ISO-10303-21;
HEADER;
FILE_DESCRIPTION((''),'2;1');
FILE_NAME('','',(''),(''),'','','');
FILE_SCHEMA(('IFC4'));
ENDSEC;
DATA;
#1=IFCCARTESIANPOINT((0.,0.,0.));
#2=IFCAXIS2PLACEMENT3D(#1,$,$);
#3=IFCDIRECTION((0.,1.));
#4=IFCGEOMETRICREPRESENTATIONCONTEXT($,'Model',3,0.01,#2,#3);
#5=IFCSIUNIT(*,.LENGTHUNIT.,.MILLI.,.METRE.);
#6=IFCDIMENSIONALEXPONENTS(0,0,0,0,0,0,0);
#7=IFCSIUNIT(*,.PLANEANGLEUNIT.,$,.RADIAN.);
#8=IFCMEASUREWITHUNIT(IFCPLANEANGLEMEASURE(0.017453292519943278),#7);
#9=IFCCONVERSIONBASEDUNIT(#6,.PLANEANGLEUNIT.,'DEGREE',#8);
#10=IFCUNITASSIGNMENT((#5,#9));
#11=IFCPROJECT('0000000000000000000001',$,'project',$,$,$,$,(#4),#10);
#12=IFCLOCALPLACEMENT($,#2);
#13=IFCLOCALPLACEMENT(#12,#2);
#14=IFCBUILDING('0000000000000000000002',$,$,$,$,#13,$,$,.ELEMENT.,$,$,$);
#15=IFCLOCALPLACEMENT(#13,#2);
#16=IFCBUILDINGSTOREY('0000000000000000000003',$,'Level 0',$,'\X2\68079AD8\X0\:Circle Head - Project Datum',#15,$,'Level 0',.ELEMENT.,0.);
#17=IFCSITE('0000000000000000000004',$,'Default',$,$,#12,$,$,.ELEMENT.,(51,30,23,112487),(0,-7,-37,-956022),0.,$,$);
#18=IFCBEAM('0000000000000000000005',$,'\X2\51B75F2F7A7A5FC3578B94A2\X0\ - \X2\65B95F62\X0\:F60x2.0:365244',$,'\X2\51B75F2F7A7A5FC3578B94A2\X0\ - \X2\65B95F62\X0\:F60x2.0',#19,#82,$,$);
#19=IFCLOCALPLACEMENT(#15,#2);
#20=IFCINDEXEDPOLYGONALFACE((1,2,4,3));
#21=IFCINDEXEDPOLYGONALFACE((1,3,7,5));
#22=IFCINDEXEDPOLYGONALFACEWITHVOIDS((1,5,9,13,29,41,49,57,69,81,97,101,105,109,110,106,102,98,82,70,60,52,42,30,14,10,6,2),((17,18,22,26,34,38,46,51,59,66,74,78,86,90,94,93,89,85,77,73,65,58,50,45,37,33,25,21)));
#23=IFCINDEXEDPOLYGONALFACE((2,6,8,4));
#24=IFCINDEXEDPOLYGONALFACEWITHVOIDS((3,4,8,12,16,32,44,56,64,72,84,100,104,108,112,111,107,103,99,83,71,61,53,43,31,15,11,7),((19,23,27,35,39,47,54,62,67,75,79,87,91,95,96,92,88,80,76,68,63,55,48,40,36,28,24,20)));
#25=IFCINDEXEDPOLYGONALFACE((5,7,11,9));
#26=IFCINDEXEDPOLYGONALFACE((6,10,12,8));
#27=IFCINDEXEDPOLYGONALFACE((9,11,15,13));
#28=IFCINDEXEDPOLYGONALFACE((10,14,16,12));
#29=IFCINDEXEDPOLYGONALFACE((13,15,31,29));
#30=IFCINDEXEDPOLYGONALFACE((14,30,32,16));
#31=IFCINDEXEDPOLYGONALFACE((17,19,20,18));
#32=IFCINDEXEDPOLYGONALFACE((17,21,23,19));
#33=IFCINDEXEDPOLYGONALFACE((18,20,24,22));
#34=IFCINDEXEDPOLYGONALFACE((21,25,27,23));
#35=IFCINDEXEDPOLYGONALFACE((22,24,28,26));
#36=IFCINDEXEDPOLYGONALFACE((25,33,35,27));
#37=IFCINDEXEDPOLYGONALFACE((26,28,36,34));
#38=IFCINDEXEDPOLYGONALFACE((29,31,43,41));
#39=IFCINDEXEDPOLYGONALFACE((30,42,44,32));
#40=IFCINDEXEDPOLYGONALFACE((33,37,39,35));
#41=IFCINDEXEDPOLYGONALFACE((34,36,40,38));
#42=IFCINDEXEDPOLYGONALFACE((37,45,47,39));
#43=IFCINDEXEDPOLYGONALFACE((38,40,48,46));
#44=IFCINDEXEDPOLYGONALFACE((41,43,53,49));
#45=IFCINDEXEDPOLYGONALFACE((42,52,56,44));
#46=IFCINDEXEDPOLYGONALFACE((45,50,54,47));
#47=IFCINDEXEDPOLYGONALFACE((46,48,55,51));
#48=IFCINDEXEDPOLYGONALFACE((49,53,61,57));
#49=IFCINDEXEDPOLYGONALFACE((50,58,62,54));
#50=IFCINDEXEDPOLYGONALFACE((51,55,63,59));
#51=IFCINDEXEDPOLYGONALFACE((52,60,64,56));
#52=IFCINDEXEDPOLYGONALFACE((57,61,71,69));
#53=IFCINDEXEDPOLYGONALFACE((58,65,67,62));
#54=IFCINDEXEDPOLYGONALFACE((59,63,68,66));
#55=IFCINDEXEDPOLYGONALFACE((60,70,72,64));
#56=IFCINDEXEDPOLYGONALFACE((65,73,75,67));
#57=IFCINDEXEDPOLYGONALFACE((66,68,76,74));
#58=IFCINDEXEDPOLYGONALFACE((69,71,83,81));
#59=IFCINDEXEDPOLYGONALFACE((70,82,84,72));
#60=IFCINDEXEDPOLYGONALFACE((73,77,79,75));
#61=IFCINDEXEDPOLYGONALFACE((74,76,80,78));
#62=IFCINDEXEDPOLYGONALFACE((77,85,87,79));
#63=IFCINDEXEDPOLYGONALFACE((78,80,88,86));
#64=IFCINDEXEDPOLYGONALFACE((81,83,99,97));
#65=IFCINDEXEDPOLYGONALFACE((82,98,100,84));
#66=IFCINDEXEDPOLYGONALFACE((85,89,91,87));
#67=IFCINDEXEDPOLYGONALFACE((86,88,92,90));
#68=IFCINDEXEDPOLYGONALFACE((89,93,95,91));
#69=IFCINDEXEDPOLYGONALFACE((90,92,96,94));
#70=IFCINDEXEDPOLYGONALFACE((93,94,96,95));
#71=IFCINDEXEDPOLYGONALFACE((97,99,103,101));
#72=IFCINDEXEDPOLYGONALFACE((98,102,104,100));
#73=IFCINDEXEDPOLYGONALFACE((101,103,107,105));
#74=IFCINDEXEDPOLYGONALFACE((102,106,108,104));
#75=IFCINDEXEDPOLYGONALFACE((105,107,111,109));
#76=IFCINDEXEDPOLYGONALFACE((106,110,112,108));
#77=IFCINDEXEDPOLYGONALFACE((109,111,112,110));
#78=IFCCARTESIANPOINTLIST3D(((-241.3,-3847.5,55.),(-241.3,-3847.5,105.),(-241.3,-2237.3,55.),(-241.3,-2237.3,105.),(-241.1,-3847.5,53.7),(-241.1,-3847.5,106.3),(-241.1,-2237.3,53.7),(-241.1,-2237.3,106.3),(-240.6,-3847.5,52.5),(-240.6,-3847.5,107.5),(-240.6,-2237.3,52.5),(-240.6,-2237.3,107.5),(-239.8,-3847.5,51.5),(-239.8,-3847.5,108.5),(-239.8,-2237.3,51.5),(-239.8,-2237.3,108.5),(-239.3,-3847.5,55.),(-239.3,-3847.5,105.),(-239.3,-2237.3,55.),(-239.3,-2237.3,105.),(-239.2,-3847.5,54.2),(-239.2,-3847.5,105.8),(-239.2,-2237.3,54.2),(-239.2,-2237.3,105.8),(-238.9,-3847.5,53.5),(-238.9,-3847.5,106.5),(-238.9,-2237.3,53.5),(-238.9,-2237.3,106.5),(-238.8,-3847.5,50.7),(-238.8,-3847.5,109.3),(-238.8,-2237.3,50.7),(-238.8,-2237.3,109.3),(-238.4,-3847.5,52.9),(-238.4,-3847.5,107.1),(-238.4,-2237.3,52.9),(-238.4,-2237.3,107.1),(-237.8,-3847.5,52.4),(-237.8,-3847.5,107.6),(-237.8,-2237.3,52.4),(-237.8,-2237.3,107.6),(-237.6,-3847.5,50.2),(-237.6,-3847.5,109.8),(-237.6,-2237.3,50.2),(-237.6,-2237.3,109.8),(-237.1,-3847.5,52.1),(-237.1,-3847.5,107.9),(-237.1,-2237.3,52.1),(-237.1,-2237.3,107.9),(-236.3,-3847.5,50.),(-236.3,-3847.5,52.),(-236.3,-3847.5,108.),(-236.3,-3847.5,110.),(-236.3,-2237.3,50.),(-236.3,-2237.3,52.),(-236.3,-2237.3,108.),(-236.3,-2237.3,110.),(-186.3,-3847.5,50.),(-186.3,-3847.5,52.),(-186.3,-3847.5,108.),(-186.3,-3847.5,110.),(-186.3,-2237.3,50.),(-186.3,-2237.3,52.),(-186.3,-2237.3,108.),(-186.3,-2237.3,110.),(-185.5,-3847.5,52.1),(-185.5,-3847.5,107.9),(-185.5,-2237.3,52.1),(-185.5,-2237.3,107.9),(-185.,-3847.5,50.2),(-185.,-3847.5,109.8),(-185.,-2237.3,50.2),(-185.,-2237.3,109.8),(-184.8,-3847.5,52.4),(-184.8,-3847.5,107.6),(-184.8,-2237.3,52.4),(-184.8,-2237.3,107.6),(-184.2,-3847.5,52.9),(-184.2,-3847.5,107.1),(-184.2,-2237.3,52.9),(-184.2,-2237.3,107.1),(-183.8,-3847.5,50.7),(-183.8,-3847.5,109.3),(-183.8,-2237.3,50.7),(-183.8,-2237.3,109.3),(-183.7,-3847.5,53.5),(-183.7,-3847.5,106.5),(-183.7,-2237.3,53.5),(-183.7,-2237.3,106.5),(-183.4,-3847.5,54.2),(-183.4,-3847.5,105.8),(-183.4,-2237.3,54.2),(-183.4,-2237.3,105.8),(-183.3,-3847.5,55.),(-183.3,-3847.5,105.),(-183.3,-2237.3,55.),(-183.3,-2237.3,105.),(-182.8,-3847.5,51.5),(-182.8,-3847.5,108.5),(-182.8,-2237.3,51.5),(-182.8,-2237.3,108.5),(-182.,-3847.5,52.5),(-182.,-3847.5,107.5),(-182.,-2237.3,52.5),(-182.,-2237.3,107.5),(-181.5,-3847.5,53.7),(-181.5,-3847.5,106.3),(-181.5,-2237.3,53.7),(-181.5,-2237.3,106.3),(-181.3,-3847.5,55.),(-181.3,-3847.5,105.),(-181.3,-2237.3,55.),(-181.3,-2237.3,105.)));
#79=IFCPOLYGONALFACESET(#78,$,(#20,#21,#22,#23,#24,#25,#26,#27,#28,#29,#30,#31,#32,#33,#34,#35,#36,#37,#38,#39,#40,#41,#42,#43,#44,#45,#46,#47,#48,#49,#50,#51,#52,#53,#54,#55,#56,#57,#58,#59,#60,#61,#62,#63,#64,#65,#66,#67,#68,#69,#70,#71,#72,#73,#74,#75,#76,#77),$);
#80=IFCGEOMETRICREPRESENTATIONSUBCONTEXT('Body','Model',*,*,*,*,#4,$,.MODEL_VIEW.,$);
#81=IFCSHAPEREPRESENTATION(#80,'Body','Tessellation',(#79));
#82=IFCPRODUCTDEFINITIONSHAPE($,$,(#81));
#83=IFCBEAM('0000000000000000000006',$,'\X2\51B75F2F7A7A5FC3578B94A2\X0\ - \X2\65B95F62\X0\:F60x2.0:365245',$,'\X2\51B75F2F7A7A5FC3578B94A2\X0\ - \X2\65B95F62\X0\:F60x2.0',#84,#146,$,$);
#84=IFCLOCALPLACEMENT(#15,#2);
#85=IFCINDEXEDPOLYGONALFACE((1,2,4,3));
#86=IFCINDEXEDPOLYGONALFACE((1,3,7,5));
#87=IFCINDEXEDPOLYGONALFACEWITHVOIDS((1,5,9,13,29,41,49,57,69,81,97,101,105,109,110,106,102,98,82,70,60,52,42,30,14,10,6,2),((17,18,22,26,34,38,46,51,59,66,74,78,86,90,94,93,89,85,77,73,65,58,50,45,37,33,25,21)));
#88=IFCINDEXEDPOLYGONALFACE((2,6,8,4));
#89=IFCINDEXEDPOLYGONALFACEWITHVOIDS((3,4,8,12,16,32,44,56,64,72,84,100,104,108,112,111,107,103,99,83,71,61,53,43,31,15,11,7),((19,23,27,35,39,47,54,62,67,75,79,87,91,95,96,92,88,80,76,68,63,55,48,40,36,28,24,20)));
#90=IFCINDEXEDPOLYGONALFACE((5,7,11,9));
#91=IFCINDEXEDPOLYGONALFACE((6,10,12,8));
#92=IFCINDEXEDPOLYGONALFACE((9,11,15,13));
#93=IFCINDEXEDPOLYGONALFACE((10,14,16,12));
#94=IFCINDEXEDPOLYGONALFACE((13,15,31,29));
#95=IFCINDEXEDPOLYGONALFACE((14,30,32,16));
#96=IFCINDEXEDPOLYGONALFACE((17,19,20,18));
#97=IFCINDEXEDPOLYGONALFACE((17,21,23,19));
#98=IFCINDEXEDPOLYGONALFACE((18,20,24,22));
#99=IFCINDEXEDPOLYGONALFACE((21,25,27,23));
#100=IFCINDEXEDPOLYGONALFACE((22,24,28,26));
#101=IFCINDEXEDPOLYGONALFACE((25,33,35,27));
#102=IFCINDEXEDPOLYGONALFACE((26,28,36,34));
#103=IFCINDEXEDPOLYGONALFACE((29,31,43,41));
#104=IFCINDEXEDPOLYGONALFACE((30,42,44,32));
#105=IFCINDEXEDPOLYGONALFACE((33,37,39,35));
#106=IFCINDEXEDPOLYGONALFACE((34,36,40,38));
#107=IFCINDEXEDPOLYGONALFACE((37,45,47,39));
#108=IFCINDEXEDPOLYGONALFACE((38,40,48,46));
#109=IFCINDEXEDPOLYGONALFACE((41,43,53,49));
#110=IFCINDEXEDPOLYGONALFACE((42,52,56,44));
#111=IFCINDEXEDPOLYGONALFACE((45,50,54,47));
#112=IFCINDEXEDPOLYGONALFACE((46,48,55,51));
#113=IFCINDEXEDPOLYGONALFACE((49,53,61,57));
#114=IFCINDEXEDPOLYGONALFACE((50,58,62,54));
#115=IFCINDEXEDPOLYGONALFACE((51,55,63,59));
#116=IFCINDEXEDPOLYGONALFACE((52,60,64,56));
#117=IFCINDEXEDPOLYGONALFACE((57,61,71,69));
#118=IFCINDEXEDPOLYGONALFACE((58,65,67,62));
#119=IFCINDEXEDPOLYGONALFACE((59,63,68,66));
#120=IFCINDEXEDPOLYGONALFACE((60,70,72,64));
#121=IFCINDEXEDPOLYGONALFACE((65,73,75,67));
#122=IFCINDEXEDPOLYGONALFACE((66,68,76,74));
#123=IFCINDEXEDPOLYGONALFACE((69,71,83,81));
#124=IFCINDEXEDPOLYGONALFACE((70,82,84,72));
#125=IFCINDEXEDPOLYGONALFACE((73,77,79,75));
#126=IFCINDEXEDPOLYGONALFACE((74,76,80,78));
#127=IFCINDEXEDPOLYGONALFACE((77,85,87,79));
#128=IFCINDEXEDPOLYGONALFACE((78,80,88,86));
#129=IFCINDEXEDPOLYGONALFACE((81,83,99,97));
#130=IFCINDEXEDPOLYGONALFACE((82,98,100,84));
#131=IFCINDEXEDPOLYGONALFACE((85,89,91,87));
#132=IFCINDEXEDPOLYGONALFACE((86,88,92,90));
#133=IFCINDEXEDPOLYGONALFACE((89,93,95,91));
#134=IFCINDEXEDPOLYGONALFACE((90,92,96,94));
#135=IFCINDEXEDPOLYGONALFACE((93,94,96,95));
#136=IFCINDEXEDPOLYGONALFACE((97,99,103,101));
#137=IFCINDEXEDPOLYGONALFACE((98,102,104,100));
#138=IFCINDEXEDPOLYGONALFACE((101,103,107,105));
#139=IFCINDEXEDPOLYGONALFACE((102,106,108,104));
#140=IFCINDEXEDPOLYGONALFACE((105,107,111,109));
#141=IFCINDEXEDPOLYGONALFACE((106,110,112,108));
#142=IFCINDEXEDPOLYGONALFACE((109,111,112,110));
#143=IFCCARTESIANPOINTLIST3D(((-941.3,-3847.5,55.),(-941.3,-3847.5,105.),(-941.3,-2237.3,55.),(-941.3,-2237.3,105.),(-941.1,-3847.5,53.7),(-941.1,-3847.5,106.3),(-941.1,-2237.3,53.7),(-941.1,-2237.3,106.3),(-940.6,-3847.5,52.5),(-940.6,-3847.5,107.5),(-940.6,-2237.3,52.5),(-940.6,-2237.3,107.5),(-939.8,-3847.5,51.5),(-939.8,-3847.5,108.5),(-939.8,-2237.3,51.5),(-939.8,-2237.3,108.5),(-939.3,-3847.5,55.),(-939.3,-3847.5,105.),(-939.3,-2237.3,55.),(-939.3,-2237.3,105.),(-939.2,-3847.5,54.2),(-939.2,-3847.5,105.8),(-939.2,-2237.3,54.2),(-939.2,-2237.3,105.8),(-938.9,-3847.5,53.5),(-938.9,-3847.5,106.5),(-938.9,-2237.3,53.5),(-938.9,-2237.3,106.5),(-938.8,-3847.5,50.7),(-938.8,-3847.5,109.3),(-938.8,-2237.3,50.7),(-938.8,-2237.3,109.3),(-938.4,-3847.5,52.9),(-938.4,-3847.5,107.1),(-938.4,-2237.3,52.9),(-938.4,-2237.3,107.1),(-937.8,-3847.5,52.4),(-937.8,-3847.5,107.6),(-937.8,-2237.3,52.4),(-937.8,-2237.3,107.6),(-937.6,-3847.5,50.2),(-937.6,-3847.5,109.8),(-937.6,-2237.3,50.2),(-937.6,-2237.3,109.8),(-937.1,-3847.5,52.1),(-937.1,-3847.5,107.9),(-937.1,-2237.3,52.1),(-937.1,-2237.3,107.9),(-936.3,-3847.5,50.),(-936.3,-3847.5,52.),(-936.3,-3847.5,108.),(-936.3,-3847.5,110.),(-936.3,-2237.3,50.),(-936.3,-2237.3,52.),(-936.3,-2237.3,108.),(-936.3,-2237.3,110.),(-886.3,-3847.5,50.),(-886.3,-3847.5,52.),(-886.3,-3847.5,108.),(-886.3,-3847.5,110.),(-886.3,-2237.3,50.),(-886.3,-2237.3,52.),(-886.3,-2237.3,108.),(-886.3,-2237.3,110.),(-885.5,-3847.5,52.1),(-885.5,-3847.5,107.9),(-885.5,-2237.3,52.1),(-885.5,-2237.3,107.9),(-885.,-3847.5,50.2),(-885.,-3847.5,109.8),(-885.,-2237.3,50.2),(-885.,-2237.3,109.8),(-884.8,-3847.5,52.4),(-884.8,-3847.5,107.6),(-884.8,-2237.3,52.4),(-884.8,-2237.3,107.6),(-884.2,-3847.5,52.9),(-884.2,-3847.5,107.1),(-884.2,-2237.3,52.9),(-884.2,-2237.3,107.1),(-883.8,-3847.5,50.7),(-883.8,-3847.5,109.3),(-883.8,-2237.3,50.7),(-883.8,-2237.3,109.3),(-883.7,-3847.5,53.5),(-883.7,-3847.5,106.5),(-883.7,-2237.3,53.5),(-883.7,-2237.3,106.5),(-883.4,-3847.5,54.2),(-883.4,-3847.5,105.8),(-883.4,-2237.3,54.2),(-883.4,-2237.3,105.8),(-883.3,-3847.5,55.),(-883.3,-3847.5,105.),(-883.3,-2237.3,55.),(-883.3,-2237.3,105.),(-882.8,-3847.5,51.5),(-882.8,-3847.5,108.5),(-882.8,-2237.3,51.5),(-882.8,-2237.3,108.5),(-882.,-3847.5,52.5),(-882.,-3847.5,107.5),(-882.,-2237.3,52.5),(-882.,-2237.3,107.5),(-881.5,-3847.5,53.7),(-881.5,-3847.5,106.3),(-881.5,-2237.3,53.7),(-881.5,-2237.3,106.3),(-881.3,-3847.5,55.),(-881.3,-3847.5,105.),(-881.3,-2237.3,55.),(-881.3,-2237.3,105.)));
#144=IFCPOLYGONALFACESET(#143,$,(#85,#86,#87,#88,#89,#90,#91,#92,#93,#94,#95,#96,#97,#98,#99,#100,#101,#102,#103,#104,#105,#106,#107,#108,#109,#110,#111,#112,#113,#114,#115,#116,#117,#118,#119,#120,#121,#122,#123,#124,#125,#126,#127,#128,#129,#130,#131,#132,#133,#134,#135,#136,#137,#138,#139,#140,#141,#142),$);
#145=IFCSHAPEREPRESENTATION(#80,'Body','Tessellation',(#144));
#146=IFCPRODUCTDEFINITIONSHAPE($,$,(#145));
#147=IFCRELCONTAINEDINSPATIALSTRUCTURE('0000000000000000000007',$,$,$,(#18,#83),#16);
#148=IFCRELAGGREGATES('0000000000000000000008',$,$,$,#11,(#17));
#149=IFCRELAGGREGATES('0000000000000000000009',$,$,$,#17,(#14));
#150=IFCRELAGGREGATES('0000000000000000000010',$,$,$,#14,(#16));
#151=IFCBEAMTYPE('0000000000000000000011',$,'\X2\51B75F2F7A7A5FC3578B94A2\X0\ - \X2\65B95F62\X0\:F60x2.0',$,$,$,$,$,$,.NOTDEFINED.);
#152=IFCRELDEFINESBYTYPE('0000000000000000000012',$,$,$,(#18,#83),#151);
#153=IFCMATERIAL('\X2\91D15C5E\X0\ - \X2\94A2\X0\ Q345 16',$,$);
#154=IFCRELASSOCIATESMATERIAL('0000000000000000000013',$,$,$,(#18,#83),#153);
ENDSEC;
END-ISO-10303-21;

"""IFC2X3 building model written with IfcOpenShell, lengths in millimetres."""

from ifc_helpers import new_model, entity, si_unit, converted_unit, direction, frame, frame_2d, origin, place, context, subcontext, project, spatial, polyline, circle_curve, parameter, trimmed, segment, composite_curve, outline, extrude, material, type_object, element, save


model = new_model("IFC2X3")

# Units and contexts
model_context = context("Model", 3, precision=0.01, world=origin(), true_north=direction((0.0, 1.0)))
body_context = subcontext(model_context, "Body", "Model", "MODEL_VIEW")
ifc_project = project(units=[si_unit("LENGTHUNIT", "METRE", prefix="MILLI"), converted_unit("PLANEANGLEUNIT", "DEGREE", entity("IfcPlaneAngleMeasure", 0.017453292519943278), si_unit("PLANEANGLEUNIT", "RADIAN"), dimensions=[0, 0, 0, 0, 0, 0, 0])], contexts=[model_context])

# Site, building, storey
site_placement = place(None, origin())
site = spatial("IfcSite", under=ifc_project, at=site_placement, Name="Default", CompositionType="ELEMENT", RefLatitude=(51, 30, 23, 112487), RefLongitude=(0, -7, -37, -956022), RefElevation=0.0)
building_placement = place(site_placement, origin())
building = spatial("IfcBuilding", under=site, at=building_placement, CompositionType="ELEMENT")
storey_placement = place(building_placement, origin())
storey = spatial("IfcBuildingStorey", under=building, at=storey_placement, Name="Level 0", ObjectType="标高:Circle Head - Project Datum", LongName="Level 0", CompositionType="ELEMENT", Elevation=0.0)

# Beams
ifc_material_1 = material(Name="金属 - 钢 Q345 16")
beam_type_1 = type_object("IfcBeamType", Name="冷弯空心型钢 - 方形:F60x2.0", PredefinedType="NOTDEFINED")
beam_1_placement = place(storey_placement, frame((-211.3, -3815.6, 110.0), z_axis=(0.0, 0.0, 1.0), x_axis=(0.0, 1.0, 0.0)))
element("IfcBeam", 1, at=beam_1_placement, inside=storey, type_object=beam_type_1, material=ifc_material_1, Name="冷弯空心型钢 - 方形:F60x2.0:365244", ObjectType="冷弯空心型钢 - 方形:F60x2.0", context=body_context, shape_type="SweptSolid", body=[
    extrude(outline(composite_curve([segment(polyline([(-25.0, -30.0), (25.0, -30.0)]), True, "CONTINUOUS"), segment(trimmed(circle_curve(frame_2d((25.0, -25.0), x_axis=(1.0, 0.0)), 5.0), [parameter(270.0)], [parameter(360.0)], True, "PARAMETER"), True, "CONTINUOUS"), segment(polyline([(30.0, -25.0), (30.0, 25.0)]), True, "CONTINUOUS"), segment(trimmed(circle_curve(frame_2d((25.0, 25.0), x_axis=(1.0, 0.0)), 5.0), [parameter(360.0)], [parameter(90.0)], True, "PARAMETER"), True, "CONTINUOUS"), segment(polyline([(25.0, 30.0), (-25.0, 30.0)]), True, "CONTINUOUS"), segment(trimmed(circle_curve(frame_2d((-25.0, 25.0), x_axis=(1.0, 0.0)), 5.0), [parameter(90.0)], [parameter(180.0)], True, "PARAMETER"), True, "CONTINUOUS"), segment(polyline([(-30.0, 25.0), (-30.0, -25.0)]), True, "CONTINUOUS"), segment(trimmed(circle_curve(frame_2d((-25.0, -25.0), x_axis=(1.0, 0.0)), 5.0), [parameter(180.0)], [parameter(270.0)], True, "PARAMETER"), True, "CONTINUOUS")], self_intersect=False), holes=[composite_curve([segment(trimmed(circle_curve(frame_2d((-25.0, -25.0), x_axis=(1.0, 0.0)), 3.0), [parameter(180.0)], [parameter(270.0)], True, "PARAMETER"), False, "CONTINUOUS"), segment(polyline([(-28.0, -25.0), (-28.0, 25.0)]), True, "CONTINUOUS"), segment(trimmed(circle_curve(frame_2d((-25.0, 25.0), x_axis=(1.0, 0.0)), 3.0), [parameter(90.0)], [parameter(180.0)], True, "PARAMETER"), False, "CONTINUOUS"), segment(polyline([(-25.0, 28.0), (25.0, 28.0)]), True, "CONTINUOUS"), segment(trimmed(circle_curve(frame_2d((25.0, 25.0), x_axis=(1.0, 0.0)), 3.0), [parameter(0.0)], [parameter(90.0)], True, "PARAMETER"), False, "CONTINUOUS"), segment(polyline([(28.0, 25.0), (28.0, -25.0)]), True, "CONTINUOUS"), segment(trimmed(circle_curve(frame_2d((25.0, -25.0), x_axis=(1.0, 0.0)), 3.0), [parameter(270.0)], [parameter(360.0)], True, "PARAMETER"), False, "CONTINUOUS"), segment(polyline([(25.0, -28.0), (-25.0, -28.0)]), True, "CONTINUOUS")], self_intersect=False)]), frame((-31.9, 0.0, -30.0), z_axis=(1.0, 0.0, 0.0), x_axis=(0.0, -1.0, 0.0)), (0.0, 0.0, 1.0), 1610.2),
])
beam_2_placement = place(storey_placement, frame((-911.3, -3815.6, 110.0), z_axis=(0.0, 0.0, 1.0), x_axis=(0.0, 1.0, 0.0)))
element("IfcBeam", 2, at=beam_2_placement, inside=storey, type_object=beam_type_1, material=ifc_material_1, Name="冷弯空心型钢 - 方形:F60x2.0:365245", ObjectType="冷弯空心型钢 - 方形:F60x2.0", context=body_context, shape_type="SweptSolid", body=[
    extrude(outline(composite_curve([segment(polyline([(-25.0, -30.0), (25.0, -30.0)]), True, "CONTINUOUS"), segment(trimmed(circle_curve(frame_2d((25.0, -25.0), x_axis=(1.0, 0.0)), 5.0), [parameter(270.0)], [parameter(360.0)], True, "PARAMETER"), True, "CONTINUOUS"), segment(polyline([(30.0, -25.0), (30.0, 25.0)]), True, "CONTINUOUS"), segment(trimmed(circle_curve(frame_2d((25.0, 25.0), x_axis=(1.0, 0.0)), 5.0), [parameter(360.0)], [parameter(90.0)], True, "PARAMETER"), True, "CONTINUOUS"), segment(polyline([(25.0, 30.0), (-25.0, 30.0)]), True, "CONTINUOUS"), segment(trimmed(circle_curve(frame_2d((-25.0, 25.0), x_axis=(1.0, 0.0)), 5.0), [parameter(90.0)], [parameter(180.0)], True, "PARAMETER"), True, "CONTINUOUS"), segment(polyline([(-30.0, 25.0), (-30.0, -25.0)]), True, "CONTINUOUS"), segment(trimmed(circle_curve(frame_2d((-25.0, -25.0), x_axis=(1.0, 0.0)), 5.0), [parameter(180.0)], [parameter(270.0)], True, "PARAMETER"), True, "CONTINUOUS")], self_intersect=False), holes=[composite_curve([segment(trimmed(circle_curve(frame_2d((-25.0, -25.0), x_axis=(1.0, 0.0)), 3.0), [parameter(180.0)], [parameter(270.0)], True, "PARAMETER"), False, "CONTINUOUS"), segment(polyline([(-28.0, -25.0), (-28.0, 25.0)]), True, "CONTINUOUS"), segment(trimmed(circle_curve(frame_2d((-25.0, 25.0), x_axis=(1.0, 0.0)), 3.0), [parameter(90.0)], [parameter(180.0)], True, "PARAMETER"), False, "CONTINUOUS"), segment(polyline([(-25.0, 28.0), (25.0, 28.0)]), True, "CONTINUOUS"), segment(trimmed(circle_curve(frame_2d((25.0, 25.0), x_axis=(1.0, 0.0)), 3.0), [parameter(0.0)], [parameter(90.0)], True, "PARAMETER"), False, "CONTINUOUS"), segment(polyline([(28.0, 25.0), (28.0, -25.0)]), True, "CONTINUOUS"), segment(trimmed(circle_curve(frame_2d((25.0, -25.0), x_axis=(1.0, 0.0)), 3.0), [parameter(270.0)], [parameter(360.0)], True, "PARAMETER"), False, "CONTINUOUS"), segment(polyline([(25.0, -28.0), (-25.0, -28.0)]), True, "CONTINUOUS")], self_intersect=False)]), frame((-31.9, 0.0, -30.0), z_axis=(1.0, 0.0, 0.0), x_axis=(0.0, -1.0, 0.0)), (0.0, 0.0, 1.0), 1610.2),
])

save(model, "model.ifc")
